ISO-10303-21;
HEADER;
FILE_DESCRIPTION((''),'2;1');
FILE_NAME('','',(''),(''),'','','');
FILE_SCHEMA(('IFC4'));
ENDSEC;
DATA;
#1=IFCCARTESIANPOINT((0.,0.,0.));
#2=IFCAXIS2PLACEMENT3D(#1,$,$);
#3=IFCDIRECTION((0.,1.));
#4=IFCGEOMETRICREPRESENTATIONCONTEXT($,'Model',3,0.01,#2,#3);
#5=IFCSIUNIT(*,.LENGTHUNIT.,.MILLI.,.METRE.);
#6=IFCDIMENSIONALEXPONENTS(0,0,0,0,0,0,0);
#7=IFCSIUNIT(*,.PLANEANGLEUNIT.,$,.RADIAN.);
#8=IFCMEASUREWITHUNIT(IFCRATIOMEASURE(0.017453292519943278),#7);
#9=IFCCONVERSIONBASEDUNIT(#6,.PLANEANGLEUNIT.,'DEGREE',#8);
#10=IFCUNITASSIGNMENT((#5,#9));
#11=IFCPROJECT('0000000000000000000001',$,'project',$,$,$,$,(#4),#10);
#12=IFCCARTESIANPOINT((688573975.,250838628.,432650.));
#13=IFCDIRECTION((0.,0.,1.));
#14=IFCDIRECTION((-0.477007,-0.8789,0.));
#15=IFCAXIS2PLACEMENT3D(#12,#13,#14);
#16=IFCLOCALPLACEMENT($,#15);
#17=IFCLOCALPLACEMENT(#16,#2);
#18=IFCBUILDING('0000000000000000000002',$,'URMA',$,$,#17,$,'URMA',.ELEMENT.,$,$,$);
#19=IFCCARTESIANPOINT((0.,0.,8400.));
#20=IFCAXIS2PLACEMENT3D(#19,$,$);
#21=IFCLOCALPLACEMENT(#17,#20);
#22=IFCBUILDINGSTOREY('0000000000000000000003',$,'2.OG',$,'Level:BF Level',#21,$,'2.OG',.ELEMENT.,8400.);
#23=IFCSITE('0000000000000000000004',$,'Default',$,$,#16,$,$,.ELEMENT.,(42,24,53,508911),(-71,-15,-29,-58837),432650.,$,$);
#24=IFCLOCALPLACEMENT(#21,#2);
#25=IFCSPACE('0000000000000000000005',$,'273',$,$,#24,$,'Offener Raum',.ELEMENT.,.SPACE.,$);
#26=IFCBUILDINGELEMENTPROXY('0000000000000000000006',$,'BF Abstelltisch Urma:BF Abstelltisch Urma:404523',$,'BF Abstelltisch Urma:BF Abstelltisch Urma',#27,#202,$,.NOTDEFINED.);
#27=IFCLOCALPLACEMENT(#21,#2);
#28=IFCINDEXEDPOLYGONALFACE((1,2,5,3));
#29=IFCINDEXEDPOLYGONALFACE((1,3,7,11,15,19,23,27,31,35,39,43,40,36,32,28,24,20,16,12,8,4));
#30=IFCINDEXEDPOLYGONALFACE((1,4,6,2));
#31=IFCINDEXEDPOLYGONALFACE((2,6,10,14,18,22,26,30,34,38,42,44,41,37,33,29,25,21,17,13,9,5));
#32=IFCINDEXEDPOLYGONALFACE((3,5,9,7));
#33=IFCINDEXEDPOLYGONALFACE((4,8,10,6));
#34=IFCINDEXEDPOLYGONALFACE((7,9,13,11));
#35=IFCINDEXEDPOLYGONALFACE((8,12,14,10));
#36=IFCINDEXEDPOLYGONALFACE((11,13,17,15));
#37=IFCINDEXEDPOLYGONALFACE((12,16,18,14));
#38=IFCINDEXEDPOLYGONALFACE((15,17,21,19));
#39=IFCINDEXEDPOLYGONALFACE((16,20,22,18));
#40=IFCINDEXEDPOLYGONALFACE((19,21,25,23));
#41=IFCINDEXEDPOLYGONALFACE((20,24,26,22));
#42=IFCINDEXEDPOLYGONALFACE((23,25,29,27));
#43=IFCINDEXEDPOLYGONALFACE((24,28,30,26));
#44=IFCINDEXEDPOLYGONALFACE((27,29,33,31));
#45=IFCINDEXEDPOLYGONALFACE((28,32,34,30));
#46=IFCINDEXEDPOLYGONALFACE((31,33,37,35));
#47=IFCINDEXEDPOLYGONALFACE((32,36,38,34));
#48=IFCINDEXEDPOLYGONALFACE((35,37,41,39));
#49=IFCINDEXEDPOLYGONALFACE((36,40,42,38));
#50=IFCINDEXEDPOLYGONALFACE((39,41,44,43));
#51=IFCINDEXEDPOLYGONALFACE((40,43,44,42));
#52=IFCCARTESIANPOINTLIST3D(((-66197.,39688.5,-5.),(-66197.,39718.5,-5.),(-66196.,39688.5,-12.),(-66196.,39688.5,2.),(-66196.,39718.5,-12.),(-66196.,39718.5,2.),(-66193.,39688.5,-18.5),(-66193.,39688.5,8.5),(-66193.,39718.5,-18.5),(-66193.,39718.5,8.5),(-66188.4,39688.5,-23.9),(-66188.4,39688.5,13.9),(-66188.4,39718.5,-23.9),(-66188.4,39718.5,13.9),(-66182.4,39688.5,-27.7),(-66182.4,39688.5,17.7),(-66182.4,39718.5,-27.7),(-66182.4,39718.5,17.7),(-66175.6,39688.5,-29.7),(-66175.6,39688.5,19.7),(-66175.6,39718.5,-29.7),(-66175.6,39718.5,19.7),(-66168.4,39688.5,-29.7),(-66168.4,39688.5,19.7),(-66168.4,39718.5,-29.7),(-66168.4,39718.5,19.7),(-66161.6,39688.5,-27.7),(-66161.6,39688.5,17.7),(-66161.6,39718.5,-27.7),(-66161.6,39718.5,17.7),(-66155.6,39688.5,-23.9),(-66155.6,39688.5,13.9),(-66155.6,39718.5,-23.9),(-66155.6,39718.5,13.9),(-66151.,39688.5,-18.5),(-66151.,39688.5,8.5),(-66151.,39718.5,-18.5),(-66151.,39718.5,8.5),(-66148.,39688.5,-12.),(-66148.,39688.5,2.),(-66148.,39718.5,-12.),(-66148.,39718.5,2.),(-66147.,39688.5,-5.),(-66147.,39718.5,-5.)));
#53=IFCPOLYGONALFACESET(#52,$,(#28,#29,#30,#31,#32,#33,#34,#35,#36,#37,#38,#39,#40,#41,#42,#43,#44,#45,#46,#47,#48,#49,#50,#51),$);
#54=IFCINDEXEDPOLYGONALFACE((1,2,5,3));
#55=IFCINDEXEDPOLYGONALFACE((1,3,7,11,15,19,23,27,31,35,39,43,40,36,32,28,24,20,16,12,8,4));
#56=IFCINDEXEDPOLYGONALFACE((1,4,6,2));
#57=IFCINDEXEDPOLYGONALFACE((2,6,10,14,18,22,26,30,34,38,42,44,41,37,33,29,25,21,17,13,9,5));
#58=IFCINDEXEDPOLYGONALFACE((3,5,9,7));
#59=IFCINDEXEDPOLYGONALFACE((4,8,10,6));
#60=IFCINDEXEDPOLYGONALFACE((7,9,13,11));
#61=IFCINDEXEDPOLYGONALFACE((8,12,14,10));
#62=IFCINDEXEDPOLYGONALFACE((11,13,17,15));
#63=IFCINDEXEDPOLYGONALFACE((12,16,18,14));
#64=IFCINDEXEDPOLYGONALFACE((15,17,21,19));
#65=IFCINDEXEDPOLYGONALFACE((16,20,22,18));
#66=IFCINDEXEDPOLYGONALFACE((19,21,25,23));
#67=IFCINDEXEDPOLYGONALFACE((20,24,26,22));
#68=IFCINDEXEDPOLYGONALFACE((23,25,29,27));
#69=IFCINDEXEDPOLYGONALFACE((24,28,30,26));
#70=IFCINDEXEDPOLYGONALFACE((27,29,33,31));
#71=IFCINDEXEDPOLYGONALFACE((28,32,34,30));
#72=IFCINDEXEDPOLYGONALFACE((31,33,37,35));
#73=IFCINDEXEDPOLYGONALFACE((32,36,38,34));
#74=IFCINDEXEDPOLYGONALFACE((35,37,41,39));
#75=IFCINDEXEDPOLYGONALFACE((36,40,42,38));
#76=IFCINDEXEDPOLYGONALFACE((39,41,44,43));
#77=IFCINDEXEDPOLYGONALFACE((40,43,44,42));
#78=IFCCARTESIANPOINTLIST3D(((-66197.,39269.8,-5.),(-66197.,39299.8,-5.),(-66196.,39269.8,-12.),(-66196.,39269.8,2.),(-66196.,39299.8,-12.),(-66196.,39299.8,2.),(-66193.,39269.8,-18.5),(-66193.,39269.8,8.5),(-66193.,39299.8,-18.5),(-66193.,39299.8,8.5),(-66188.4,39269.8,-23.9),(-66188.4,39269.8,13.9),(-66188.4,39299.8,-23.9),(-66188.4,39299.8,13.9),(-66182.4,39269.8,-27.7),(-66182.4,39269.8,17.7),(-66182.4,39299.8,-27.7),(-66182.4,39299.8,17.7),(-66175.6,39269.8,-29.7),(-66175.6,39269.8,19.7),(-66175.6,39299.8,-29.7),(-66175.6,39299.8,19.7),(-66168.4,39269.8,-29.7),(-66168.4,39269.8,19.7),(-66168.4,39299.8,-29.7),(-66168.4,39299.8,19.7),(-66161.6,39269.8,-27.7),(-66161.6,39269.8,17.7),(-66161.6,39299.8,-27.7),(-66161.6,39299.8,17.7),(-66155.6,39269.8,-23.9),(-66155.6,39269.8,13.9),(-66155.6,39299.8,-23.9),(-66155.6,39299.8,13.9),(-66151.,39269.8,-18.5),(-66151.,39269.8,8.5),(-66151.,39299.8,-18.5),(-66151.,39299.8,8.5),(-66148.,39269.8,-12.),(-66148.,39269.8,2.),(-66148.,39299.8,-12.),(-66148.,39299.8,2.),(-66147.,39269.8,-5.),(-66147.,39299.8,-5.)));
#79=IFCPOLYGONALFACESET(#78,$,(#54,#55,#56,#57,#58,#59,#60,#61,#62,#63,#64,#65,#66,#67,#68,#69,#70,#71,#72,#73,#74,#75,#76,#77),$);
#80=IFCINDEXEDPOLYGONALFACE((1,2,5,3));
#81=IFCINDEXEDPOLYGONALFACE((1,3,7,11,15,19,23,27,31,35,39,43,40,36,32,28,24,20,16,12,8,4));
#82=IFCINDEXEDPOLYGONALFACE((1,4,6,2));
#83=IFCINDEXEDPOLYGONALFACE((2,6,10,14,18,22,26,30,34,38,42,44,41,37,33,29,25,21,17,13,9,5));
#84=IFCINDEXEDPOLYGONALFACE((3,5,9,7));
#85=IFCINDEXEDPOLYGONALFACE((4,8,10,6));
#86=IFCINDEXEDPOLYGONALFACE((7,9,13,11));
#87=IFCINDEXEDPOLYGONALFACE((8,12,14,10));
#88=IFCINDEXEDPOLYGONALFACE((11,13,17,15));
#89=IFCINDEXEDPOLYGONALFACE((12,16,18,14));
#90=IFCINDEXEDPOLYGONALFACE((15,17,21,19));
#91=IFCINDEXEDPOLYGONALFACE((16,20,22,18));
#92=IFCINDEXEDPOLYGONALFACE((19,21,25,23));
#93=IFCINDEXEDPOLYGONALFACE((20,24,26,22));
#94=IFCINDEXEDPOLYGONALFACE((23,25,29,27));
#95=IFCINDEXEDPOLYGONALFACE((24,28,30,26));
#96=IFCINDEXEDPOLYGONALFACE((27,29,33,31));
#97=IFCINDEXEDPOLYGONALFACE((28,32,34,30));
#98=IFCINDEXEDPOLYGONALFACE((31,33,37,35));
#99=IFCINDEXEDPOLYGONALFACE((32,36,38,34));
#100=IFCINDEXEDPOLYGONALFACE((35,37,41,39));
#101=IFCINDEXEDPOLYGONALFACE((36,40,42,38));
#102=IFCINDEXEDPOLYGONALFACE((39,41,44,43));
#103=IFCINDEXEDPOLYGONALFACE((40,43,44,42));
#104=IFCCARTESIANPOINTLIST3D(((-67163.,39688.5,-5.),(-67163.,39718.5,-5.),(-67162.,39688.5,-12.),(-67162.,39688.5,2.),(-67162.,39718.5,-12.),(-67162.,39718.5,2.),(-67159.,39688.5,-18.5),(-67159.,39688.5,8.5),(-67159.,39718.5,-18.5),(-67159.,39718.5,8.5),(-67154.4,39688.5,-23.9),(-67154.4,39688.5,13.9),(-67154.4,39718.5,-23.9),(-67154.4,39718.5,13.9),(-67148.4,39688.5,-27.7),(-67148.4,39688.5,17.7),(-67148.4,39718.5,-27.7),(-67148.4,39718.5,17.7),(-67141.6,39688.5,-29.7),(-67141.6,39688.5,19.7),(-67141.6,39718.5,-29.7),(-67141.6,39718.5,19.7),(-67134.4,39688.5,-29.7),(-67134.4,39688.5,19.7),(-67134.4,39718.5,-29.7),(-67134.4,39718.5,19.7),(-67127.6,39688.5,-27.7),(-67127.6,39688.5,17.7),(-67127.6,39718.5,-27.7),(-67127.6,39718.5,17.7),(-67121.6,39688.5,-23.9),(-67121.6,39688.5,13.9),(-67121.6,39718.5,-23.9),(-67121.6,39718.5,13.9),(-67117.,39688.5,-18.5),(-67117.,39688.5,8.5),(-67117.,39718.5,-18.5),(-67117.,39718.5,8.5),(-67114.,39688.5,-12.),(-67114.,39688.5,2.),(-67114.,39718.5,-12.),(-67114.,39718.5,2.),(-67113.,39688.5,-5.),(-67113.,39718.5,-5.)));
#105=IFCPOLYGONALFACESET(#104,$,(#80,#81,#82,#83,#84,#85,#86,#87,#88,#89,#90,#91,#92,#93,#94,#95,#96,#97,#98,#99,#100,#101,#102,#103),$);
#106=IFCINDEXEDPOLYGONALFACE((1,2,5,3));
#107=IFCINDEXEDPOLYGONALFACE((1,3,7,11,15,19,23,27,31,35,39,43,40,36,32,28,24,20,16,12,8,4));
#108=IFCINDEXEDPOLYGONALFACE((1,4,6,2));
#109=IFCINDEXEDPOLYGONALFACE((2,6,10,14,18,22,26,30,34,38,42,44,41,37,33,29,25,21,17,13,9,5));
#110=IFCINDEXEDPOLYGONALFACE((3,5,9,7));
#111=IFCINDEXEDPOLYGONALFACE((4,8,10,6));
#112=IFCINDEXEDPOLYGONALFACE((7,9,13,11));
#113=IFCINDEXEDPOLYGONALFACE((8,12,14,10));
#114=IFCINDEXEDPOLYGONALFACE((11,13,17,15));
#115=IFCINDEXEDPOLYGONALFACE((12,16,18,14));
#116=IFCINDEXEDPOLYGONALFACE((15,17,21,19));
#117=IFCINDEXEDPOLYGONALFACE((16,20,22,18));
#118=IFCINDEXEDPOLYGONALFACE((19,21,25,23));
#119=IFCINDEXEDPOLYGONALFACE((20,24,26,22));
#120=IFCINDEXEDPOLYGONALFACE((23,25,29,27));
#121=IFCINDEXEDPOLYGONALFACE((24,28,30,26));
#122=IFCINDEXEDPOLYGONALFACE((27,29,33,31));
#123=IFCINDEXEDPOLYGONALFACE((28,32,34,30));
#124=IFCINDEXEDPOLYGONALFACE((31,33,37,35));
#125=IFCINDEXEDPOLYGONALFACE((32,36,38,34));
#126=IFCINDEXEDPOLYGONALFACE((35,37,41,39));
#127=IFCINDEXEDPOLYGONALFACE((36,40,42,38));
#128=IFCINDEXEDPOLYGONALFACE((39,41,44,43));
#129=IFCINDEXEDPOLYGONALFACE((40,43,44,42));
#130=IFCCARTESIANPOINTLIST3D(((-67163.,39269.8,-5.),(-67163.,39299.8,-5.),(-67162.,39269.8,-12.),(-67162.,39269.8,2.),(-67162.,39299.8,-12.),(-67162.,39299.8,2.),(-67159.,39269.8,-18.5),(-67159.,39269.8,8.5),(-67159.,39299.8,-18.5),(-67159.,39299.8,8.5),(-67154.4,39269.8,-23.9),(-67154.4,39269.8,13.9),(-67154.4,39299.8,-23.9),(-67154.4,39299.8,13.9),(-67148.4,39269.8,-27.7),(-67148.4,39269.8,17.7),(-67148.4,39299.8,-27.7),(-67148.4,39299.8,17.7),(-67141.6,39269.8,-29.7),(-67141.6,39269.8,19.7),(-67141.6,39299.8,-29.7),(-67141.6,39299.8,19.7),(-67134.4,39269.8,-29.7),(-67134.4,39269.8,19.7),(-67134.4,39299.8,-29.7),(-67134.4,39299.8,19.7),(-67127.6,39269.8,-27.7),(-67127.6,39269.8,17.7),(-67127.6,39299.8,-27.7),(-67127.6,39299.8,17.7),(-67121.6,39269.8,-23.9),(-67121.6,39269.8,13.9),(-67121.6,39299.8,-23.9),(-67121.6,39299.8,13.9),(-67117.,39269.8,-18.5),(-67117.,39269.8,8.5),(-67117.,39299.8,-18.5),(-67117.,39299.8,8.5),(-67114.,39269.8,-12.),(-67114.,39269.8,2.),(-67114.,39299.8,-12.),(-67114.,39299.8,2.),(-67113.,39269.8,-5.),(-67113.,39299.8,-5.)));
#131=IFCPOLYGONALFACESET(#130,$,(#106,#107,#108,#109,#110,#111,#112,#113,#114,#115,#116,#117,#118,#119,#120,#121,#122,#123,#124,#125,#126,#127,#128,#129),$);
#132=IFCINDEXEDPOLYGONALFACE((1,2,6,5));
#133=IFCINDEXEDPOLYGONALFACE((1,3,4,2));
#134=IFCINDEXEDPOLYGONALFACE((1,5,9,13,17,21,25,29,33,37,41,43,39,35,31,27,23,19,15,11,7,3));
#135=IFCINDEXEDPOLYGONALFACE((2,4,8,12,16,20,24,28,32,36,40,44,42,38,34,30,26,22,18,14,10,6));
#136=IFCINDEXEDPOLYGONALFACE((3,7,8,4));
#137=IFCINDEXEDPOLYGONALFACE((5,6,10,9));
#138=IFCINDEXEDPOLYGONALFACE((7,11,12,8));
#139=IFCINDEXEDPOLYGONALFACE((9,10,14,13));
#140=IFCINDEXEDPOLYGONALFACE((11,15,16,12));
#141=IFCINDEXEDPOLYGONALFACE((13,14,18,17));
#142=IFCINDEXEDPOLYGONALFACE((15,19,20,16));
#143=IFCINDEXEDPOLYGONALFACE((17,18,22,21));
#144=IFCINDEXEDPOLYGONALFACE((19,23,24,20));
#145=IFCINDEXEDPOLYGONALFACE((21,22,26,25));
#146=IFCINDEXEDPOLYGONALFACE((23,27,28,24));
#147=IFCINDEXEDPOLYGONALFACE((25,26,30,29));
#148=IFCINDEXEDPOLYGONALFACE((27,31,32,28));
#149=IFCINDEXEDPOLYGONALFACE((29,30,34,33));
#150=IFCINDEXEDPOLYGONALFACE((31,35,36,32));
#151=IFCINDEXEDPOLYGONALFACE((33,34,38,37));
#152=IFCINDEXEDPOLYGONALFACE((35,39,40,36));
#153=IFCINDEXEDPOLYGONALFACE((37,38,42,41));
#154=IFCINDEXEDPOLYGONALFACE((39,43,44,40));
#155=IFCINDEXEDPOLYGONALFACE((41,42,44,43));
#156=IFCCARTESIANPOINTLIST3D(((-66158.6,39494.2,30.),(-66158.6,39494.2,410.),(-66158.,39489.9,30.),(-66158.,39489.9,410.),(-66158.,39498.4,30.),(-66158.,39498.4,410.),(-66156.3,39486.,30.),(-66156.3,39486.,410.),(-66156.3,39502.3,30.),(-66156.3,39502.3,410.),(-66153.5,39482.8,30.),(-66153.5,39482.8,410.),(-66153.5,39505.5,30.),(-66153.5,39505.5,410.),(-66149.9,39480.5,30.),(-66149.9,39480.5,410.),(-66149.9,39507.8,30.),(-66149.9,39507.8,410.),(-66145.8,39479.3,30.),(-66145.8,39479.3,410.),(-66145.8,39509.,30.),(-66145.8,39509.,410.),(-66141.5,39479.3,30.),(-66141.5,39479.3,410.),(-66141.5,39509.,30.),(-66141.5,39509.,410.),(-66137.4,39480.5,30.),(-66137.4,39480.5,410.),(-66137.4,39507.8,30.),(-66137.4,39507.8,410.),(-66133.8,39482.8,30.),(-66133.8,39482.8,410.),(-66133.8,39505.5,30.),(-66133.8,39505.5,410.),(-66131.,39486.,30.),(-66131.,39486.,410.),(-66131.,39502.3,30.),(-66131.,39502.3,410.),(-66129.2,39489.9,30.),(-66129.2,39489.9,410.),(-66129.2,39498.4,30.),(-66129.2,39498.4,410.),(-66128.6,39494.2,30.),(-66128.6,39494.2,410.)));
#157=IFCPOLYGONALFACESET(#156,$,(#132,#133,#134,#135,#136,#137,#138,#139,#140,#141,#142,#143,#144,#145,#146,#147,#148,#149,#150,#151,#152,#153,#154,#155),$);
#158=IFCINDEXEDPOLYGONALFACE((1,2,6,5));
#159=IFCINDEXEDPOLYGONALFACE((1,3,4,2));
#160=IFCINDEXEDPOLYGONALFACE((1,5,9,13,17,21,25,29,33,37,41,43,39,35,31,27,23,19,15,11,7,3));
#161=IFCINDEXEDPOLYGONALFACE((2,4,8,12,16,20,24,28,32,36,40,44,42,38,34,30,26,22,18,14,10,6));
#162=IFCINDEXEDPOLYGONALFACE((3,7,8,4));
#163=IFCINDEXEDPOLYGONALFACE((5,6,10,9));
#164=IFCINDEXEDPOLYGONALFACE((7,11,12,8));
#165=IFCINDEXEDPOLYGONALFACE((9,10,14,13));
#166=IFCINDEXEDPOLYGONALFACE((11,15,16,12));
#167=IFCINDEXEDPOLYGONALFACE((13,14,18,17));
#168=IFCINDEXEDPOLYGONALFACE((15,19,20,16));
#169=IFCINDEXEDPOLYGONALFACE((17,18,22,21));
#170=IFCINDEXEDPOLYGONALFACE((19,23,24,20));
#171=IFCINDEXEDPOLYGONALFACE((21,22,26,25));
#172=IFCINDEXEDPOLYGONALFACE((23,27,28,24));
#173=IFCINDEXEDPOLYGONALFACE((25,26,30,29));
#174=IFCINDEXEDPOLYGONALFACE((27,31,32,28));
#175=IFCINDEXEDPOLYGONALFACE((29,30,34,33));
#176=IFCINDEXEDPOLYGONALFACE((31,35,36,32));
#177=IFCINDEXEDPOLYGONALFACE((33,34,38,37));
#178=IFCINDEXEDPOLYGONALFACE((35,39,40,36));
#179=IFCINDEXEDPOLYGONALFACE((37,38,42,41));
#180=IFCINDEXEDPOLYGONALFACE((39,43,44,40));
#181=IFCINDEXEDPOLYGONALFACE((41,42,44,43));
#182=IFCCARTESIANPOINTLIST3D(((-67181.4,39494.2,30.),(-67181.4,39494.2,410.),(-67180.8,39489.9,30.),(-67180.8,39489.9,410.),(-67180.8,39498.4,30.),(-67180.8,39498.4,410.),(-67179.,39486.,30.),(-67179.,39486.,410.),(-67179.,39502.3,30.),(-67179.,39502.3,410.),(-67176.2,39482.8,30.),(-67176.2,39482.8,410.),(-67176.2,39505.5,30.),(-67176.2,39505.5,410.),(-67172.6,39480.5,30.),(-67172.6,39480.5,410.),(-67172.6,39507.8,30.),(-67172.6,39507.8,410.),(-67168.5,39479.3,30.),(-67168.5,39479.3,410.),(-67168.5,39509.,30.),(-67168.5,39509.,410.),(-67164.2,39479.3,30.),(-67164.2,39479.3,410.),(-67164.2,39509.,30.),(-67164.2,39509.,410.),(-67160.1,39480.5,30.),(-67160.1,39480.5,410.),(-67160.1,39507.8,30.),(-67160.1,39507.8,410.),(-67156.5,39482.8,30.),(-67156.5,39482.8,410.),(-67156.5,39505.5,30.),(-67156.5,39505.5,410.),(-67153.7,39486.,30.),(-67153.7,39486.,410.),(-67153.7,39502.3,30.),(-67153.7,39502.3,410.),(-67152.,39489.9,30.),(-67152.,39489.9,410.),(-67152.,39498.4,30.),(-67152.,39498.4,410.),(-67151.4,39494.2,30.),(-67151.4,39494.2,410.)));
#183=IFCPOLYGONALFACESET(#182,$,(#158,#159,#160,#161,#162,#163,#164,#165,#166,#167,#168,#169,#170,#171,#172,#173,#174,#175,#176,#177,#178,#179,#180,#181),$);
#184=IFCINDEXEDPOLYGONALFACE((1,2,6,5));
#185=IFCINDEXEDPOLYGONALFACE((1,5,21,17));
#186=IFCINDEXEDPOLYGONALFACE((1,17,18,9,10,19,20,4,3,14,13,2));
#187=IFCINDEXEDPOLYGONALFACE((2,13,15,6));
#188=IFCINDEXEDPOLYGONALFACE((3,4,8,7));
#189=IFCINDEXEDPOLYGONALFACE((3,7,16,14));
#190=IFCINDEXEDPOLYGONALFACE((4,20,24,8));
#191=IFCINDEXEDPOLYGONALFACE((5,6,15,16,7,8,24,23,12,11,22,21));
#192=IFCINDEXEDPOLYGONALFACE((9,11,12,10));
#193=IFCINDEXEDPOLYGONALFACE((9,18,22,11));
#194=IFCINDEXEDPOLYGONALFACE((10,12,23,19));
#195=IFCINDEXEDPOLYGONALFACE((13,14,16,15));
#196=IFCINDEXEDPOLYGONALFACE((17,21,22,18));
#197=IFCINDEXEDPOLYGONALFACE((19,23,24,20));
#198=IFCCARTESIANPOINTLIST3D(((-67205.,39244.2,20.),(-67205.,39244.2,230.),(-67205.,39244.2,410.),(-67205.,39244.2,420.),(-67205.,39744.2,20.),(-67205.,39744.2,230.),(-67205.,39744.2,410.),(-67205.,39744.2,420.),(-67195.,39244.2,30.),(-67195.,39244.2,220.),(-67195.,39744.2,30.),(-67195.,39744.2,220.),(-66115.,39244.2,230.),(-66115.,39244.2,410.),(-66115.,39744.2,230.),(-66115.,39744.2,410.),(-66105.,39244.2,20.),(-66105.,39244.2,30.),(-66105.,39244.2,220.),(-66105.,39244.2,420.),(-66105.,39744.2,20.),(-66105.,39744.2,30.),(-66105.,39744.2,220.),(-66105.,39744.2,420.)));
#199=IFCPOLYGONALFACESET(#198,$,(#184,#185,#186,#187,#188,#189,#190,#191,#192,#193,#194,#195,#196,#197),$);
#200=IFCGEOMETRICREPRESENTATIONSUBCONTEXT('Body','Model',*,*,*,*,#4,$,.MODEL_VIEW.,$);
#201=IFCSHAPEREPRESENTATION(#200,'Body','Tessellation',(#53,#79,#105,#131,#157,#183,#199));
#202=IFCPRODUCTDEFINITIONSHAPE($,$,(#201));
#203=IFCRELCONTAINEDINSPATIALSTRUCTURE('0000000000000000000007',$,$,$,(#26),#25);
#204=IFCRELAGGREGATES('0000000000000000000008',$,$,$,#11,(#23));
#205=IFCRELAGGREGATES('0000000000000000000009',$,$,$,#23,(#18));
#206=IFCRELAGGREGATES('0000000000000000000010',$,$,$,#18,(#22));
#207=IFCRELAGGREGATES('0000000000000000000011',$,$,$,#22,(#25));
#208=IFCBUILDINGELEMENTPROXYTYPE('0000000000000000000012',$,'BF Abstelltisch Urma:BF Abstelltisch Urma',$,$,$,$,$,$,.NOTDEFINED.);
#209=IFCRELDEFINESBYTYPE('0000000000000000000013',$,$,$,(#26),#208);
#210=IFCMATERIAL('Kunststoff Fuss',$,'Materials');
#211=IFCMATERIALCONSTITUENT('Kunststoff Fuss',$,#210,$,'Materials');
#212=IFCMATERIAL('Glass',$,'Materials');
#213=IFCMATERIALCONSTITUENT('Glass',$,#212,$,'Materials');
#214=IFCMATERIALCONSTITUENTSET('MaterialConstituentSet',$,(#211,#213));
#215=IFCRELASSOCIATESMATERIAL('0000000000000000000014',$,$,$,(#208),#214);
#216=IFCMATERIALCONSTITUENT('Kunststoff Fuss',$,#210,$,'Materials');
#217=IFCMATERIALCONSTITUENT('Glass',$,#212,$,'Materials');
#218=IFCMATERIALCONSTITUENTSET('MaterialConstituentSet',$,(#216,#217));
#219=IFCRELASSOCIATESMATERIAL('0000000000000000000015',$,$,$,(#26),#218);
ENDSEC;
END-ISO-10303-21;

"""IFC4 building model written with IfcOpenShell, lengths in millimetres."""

from ifc_helpers import new_model, entity, si_unit, converted_unit, direction, frame, origin, place, context, subcontext, project, spatial, arc, indexed_curve, outline, extrude, source, transform, mapped, material, constituent, constituent_set, type_object, type_shapes, element, save


model = new_model("IFC4")

# Units and contexts
model_context = context("Model", 3, precision=0.01, world=origin(), true_north=direction((0.0, 1.0)))
body_context = subcontext(model_context, "Body", "Model", "MODEL_VIEW")
ifc_project = project(units=[si_unit("LENGTHUNIT", "METRE", prefix="MILLI"), converted_unit("PLANEANGLEUNIT", "DEGREE", entity("IfcRatioMeasure", 0.017453292519943278), si_unit("PLANEANGLEUNIT", "RADIAN"), dimensions=[0, 0, 0, 0, 0, 0, 0])], contexts=[model_context])

# Site, building, storey
site_placement = place(None, frame((688573975.0, 250838628.0, 432650.0), z_axis=(0.0, 0.0, 1.0), x_axis=(-0.477007, -0.8789, 0.0)))
site = spatial("IfcSite", under=ifc_project, at=site_placement, Name="Default", CompositionType="ELEMENT", RefLatitude=(42, 24, 53, 508911), RefLongitude=(-71, -15, -29, -58837), RefElevation=432650.0)
building_placement = place(site_placement, origin())
building = spatial("IfcBuilding", under=site, at=building_placement, Name="URMA", LongName="URMA", CompositionType="ELEMENT")
storey_placement = place(building_placement, frame((0.0, 0.0, 8400.0)))
storey = spatial("IfcBuildingStorey", under=building, at=storey_placement, Name="2.OG", ObjectType="Level:BF Level", LongName="2.OG", CompositionType="ELEMENT", Elevation=8400.0)

# Shared definitions
space_1_placement = place(storey_placement, origin())
space_1 = spatial("IfcSpace", under=storey, at=space_1_placement, Name="273", LongName="Offener Raum", CompositionType="ELEMENT", PredefinedType="SPACE")

# Shared definitions
ifc_material_1 = material(Name="Glass", Category="Materials")

# Building element proxy
ifc_material_2 = material(Name="Kunststoff Fuss", Category="Materials")
ifc_constituent_1 = constituent(ifc_material_2, Name="Kunststoff Fuss", Category="Materials")
ifc_constituent_2 = constituent(ifc_material_1, Name="Glass", Category="Materials")
ifc_constituent_set_1 = constituent_set(constituents=[ifc_constituent_1, ifc_constituent_2], Name="MaterialConstituentSet")
ifc_constituent_3 = constituent(ifc_material_2, Name="Kunststoff Fuss", Category="Materials")
ifc_constituent_4 = constituent(ifc_material_1, Name="Glass", Category="Materials")
ifc_constituent_set_2 = constituent_set(constituents=[ifc_constituent_3, ifc_constituent_4], Name="MaterialConstituentSet")
building_element_proxy_type_1 = type_object("IfcBuildingElementProxyType", Name="BF Abstelltisch Urma:BF Abstelltisch Urma", PredefinedType="NOTDEFINED", material=ifc_constituent_set_2)
shared_shape_1 = source(origin(), body_context, "Body", "SweptSolid", [
    extrude(outline(indexed_curve([(-25.0, 0.0), (0.0, -25.0), (25.0, 0.0), (0.0, 25.0)], segments=[arc(1, 2, 3), arc(3, 4, 1)], self_intersect=False)), frame((483.0, 194.3, 25.0), z_axis=(0.0, 1.0, 0.0), x_axis=(-1.0, 0.0, 0.0)), (0.0, 0.0, 1.0), 30.0),
    extrude(outline(indexed_curve([(-25.0, 0.0), (0.0, -25.0), (25.0, 0.0), (0.0, 25.0)], segments=[arc(1, 2, 3), arc(3, 4, 1)], self_intersect=False)), frame((483.0, -224.3, 25.0), z_axis=(0.0, 1.0, 0.0), x_axis=(-1.0, 0.0, 0.0)), (0.0, 0.0, 1.0), 30.0),
    extrude(outline(indexed_curve([(-25.0, 0.0), (0.0, -25.0), (25.0, 0.0), (0.0, 25.0)], segments=[arc(1, 2, 3), arc(3, 4, 1)], self_intersect=False)), frame((-483.0, 194.3, 25.0), z_axis=(0.0, 1.0, 0.0), x_axis=(1.0, 0.0, 0.0)), (0.0, 0.0, 1.0), 30.0),
    extrude(outline(indexed_curve([(-25.0, 0.0), (0.0, -25.0), (25.0, 0.0), (0.0, 25.0)], segments=[arc(1, 2, 3), arc(3, 4, 1)], self_intersect=False)), frame((-483.0, -224.3, 25.0), z_axis=(0.0, 1.0, 0.0), x_axis=(1.0, 0.0, 0.0)), (0.0, 0.0, 1.0), 30.0),
    extrude(outline(indexed_curve([(-15.0, 0.0), (0.0, -15.0), (15.0, 0.0), (0.0, 15.0)], segments=[arc(1, 2, 3), arc(3, 4, 1)], self_intersect=False)), frame((511.4, 0.0, 60.0), z_axis=(0.0, 0.0, 1.0), x_axis=(-1.0, 0.0, 0.0)), (0.0, 0.0, 1.0), 380.0),
    extrude(outline(indexed_curve([(-15.0, 0.0), (0.0, -15.0), (15.0, 0.0), (0.0, 15.0)], segments=[arc(1, 2, 3), arc(3, 4, 1)], self_intersect=False)), frame((-511.4, 0.0, 60.0)), (0.0, 0.0, 1.0), 380.0),
    extrude(outline(indexed_curve([(191.7, -550.0), (201.7, -550.0), (201.7, 550.0), (-8.3, 550.0), (-8.3, -540.0), (-188.3, -540.0), (-188.3, 550.0), (-198.3, 550.0), (-198.3, -550.0), (1.7, -550.0), (1.7, 540.0), (191.7, 540.0), (191.7, -550.0)], self_intersect=False)), frame((0.0, -250.0, 251.7), z_axis=(0.0, 1.0, 0.0), x_axis=(0.0, 0.0, -1.0)), (0.0, 0.0, 1.0), 500.0),
])
type_shapes(building_element_proxy_type_1, [shared_shape_1])
proxy_1_placement = place(space_1_placement, frame((-66655.0, 39494.2, -30.0)))
element("IfcBuildingElementProxy", 1, at=proxy_1_placement, inside=space_1, type_object=building_element_proxy_type_1, material=ifc_constituent_set_1, Name="BF Abstelltisch Urma:BF Abstelltisch Urma:404523", ObjectType="BF Abstelltisch Urma:BF Abstelltisch Urma", PredefinedType="NOTDEFINED", context=body_context, shape_type="MappedRepresentation", body=[
    mapped(shared_shape_1, transform((0.0, 0.0, 0.0), scale=1.0)),
])

save(model, "model.ifc")
